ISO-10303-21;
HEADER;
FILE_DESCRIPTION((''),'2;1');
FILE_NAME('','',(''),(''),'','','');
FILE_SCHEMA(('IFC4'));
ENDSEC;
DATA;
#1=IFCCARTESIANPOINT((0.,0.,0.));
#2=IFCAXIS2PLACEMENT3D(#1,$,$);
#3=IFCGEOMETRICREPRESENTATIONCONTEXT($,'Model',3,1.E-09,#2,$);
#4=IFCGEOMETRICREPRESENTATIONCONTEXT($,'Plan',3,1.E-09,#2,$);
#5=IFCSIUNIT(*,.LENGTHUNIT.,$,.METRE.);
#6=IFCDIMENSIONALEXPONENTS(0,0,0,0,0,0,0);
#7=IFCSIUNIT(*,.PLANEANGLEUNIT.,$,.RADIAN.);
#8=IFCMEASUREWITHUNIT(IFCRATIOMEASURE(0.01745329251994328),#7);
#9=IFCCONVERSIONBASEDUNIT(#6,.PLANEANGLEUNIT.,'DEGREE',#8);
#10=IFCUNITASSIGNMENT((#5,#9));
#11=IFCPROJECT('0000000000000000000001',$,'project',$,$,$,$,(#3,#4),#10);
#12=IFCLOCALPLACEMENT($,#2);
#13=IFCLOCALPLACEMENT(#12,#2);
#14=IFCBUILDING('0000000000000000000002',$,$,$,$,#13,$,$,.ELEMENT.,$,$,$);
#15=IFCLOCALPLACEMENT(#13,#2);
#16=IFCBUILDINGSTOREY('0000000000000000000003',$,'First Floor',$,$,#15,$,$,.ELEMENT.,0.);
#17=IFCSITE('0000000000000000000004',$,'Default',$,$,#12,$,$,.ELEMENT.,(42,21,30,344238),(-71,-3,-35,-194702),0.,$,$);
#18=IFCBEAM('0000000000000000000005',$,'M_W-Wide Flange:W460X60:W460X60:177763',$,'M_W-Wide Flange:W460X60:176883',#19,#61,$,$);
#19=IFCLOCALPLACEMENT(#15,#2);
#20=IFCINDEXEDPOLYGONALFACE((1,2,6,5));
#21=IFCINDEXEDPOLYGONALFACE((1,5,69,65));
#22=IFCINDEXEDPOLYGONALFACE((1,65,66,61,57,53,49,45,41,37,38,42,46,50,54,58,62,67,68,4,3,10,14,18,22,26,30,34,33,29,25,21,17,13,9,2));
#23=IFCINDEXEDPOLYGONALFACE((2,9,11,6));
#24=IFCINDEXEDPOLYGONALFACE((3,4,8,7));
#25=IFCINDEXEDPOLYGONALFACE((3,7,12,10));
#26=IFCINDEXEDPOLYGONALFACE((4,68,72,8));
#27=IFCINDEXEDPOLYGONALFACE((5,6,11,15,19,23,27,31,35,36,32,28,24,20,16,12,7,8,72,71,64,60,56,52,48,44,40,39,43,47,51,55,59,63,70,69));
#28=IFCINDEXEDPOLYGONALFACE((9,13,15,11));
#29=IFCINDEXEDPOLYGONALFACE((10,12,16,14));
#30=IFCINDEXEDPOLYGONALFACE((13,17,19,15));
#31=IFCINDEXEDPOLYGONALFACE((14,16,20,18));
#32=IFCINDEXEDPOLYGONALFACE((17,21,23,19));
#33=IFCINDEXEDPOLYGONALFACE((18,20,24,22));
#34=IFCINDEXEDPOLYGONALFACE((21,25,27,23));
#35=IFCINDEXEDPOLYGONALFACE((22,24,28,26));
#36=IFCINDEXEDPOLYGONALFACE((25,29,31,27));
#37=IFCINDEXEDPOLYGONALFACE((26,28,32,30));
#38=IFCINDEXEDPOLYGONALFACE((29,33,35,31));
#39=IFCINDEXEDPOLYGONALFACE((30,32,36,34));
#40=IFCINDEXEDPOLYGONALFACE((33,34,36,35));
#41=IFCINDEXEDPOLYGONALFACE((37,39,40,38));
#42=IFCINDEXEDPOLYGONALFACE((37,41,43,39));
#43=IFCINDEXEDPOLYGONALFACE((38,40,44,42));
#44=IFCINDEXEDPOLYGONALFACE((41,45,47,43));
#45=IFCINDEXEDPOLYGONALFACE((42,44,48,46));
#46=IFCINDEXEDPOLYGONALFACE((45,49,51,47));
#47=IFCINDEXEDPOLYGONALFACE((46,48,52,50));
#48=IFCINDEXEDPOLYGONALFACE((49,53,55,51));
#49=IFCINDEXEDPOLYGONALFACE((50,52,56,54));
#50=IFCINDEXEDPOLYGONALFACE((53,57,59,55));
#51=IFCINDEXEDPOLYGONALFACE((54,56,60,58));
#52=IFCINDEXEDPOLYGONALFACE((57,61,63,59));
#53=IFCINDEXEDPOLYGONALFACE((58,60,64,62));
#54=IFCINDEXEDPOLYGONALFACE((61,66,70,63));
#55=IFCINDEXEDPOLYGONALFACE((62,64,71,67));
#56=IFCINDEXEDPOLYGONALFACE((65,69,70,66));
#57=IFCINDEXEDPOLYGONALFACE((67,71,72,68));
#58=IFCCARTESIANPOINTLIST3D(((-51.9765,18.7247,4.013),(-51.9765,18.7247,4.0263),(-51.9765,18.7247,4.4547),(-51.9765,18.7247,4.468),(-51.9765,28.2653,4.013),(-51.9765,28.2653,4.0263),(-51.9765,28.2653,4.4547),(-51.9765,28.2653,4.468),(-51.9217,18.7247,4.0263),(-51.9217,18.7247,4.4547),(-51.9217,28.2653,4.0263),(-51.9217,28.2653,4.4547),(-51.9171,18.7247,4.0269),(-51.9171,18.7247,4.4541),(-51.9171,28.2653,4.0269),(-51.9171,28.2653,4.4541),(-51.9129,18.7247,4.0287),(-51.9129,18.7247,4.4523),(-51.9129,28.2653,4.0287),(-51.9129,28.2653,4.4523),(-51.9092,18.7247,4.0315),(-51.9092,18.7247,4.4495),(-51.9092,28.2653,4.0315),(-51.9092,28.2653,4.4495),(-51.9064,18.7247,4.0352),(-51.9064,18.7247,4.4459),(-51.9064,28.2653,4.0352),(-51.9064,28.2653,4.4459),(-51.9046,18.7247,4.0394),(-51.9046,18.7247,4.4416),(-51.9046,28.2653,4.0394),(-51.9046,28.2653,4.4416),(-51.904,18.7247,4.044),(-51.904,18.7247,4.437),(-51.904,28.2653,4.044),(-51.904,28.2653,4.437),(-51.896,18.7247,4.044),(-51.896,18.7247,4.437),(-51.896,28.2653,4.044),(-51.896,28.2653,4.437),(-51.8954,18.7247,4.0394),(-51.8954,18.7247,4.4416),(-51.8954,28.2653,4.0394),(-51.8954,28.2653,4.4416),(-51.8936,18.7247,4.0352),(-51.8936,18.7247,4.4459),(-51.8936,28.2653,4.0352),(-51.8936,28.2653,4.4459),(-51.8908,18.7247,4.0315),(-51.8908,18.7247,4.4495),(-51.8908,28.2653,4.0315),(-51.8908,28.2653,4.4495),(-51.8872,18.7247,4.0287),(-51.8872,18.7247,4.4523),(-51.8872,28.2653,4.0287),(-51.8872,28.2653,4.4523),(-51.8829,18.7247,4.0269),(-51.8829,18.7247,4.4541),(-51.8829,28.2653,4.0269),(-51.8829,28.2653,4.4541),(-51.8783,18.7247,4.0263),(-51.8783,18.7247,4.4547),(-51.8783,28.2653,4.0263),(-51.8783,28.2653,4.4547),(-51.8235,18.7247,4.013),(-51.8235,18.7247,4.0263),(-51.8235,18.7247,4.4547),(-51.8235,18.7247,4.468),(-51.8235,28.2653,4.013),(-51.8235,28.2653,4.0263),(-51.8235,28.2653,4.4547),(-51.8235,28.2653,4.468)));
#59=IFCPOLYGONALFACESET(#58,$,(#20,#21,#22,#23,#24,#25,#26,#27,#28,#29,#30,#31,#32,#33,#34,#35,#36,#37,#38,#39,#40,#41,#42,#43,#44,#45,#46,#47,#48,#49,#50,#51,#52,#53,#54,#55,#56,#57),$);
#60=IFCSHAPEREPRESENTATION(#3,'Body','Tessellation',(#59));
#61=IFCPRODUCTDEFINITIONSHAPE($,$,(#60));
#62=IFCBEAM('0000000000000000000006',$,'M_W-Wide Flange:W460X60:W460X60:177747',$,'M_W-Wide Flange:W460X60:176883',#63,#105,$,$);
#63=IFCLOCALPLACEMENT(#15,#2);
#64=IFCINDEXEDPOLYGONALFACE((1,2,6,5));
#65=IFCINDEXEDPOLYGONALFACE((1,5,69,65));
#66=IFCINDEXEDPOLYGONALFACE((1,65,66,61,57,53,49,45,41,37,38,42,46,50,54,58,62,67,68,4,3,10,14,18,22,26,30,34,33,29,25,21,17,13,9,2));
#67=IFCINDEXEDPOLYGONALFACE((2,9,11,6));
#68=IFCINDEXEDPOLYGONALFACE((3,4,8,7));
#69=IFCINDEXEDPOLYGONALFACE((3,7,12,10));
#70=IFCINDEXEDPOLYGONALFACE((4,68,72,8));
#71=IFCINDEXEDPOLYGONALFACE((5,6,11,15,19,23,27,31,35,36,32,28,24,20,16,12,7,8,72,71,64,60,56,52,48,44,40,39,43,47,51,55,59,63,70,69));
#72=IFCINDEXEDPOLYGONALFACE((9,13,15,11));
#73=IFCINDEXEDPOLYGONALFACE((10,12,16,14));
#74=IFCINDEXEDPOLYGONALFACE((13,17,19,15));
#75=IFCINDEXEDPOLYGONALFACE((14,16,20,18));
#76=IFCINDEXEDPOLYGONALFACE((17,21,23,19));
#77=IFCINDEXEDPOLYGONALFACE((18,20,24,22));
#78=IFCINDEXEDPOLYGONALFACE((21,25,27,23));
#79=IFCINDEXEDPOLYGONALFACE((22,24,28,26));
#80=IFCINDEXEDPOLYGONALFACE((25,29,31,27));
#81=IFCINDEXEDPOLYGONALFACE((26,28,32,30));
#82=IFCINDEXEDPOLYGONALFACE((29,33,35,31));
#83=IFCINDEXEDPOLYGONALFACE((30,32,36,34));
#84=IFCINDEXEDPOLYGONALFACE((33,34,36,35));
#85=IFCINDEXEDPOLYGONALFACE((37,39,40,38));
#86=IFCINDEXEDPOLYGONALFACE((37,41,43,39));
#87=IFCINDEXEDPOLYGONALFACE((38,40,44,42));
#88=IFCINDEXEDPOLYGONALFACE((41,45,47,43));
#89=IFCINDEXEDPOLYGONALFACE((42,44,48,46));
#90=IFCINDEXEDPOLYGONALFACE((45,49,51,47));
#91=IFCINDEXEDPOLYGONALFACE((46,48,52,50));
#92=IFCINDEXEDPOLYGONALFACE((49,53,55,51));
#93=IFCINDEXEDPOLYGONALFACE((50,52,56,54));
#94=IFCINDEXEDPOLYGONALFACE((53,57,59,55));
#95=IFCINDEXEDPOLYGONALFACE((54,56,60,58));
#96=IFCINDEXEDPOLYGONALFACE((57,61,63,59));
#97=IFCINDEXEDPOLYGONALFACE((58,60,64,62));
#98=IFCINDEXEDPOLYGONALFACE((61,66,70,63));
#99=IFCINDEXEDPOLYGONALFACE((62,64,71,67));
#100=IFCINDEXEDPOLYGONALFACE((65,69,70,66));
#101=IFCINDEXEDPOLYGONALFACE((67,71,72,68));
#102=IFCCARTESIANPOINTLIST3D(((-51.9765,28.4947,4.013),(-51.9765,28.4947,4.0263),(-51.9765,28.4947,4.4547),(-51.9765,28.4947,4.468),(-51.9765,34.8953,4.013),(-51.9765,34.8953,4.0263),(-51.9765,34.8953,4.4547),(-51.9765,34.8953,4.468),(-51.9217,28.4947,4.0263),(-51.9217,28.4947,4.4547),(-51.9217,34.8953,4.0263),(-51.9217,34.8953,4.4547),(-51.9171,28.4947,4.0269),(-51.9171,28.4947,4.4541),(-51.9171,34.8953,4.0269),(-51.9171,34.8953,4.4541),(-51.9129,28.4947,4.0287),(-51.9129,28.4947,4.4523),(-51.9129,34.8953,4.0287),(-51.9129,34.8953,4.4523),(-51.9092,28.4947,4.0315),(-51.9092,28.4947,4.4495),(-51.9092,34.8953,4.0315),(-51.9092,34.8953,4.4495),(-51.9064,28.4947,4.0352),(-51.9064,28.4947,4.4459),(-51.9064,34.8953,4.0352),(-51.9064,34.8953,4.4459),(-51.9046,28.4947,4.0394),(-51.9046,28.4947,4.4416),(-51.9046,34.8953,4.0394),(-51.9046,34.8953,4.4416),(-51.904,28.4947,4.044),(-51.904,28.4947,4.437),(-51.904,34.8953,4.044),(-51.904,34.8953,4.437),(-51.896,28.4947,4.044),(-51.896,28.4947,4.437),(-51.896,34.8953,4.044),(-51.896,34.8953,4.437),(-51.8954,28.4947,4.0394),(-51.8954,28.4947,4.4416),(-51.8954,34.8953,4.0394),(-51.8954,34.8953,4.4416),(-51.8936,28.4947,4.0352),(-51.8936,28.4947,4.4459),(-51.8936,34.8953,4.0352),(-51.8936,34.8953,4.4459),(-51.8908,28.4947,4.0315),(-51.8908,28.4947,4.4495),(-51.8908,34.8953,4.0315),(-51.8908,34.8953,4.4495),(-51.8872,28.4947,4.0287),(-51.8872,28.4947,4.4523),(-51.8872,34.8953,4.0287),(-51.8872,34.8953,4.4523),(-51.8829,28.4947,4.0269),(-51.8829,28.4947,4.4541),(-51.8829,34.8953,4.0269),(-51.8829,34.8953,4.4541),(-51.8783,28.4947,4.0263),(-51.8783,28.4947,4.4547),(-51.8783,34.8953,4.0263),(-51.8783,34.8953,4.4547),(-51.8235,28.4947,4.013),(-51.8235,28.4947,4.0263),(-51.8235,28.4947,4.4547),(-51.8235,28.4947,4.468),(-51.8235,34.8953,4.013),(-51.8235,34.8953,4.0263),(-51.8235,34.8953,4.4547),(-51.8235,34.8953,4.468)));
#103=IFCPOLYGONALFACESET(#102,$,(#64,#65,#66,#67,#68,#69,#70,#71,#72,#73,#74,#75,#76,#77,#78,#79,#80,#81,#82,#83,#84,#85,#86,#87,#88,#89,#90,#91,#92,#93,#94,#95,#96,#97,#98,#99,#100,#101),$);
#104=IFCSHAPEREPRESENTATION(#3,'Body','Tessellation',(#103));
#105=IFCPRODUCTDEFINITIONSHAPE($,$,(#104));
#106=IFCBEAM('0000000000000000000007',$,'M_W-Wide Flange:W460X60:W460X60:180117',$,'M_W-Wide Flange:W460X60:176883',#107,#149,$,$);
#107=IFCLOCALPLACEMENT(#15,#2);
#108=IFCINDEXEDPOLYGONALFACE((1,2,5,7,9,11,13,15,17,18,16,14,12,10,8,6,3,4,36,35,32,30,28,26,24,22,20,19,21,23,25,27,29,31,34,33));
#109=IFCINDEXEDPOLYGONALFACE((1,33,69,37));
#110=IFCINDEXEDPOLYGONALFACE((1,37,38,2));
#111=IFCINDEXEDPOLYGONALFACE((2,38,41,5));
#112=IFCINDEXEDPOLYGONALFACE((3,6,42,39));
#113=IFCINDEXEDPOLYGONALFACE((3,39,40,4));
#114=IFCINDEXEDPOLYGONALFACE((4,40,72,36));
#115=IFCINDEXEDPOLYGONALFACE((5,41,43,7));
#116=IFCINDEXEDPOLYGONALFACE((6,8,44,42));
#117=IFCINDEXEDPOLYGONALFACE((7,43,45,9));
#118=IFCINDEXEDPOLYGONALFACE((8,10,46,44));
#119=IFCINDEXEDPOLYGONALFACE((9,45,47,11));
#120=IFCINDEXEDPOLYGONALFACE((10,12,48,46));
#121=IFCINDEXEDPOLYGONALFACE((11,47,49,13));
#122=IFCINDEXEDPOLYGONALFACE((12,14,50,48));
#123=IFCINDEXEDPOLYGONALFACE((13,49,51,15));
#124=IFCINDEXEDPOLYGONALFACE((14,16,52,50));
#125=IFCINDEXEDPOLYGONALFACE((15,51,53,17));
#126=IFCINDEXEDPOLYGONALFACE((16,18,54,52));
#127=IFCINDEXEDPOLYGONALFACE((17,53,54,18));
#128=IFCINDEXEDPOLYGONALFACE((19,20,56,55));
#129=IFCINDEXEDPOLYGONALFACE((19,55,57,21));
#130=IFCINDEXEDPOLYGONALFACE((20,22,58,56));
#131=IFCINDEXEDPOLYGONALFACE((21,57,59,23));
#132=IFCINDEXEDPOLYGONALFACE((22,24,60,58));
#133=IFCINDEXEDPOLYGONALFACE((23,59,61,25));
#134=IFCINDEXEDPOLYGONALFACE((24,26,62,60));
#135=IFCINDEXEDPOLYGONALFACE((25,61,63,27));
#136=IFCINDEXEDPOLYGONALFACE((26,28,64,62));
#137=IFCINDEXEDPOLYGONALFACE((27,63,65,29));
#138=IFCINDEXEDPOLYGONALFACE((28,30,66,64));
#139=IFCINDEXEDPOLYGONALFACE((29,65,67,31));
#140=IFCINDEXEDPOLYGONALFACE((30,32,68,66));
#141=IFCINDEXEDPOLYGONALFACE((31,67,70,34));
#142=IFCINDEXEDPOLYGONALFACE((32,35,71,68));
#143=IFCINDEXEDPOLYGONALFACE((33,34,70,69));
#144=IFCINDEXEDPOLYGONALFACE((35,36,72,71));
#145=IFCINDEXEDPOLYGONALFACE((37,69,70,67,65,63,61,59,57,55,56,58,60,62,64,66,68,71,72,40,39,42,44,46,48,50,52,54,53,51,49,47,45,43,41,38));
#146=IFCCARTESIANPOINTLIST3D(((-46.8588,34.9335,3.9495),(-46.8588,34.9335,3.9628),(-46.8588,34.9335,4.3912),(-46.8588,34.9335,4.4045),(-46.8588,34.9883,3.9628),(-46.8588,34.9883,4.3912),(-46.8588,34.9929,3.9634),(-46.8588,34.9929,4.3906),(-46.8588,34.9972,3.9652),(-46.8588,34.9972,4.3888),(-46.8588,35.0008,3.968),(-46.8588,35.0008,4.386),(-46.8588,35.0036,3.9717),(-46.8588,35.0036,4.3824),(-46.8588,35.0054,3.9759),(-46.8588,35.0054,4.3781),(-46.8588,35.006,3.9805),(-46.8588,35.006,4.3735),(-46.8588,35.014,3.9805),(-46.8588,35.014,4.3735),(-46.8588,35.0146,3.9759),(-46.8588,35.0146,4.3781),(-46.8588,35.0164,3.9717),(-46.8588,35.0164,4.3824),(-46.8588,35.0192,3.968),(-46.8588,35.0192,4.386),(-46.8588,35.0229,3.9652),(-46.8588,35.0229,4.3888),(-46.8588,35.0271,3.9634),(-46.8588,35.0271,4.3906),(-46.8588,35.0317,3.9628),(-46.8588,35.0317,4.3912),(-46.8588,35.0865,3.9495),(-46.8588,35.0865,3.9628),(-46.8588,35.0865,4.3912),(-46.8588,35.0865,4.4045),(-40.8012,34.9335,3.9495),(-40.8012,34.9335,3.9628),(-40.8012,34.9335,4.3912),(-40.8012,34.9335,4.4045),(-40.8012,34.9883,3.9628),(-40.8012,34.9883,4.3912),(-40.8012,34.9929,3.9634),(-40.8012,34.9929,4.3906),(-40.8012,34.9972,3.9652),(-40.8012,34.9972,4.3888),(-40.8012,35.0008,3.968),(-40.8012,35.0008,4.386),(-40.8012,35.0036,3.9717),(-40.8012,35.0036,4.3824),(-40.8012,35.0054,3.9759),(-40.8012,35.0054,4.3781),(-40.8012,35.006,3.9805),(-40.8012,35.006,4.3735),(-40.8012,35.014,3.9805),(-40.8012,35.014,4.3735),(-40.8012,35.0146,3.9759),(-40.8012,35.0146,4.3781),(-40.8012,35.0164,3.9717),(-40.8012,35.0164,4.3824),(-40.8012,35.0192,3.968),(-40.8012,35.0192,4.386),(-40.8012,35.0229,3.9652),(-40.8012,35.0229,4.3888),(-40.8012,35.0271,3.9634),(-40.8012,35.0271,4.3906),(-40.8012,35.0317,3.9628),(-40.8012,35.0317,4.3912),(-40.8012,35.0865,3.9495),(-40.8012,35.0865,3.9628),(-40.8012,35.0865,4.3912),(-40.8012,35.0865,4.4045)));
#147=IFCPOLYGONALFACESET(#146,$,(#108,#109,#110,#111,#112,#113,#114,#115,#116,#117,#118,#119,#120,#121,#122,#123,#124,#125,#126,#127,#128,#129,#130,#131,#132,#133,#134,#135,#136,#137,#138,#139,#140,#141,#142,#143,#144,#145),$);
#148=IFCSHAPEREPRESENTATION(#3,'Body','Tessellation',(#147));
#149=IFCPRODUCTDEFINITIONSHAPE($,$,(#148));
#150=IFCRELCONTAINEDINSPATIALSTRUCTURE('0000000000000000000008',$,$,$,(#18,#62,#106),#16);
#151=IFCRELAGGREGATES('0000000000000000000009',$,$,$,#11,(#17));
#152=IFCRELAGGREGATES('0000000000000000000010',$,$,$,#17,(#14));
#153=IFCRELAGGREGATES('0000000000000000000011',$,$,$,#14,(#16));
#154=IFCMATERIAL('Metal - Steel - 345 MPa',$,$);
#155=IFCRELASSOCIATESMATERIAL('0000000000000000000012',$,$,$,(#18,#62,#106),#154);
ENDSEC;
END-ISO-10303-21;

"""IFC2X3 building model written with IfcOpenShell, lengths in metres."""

from ifc_helpers import new_model, entity, si_unit, converted_unit, frame, frame_2d, origin, place, context, project, spatial, polyline, circle_curve, parameter, trimmed, segment, composite_curve, outline, extrude, material, element, save


model = new_model("IFC2X3")

# Units and contexts
model_context = context("Model", 3, precision=1e-09, world=origin())
plan_context = context("Plan", 3, precision=1e-09, world=origin())
ifc_project = project(units=[si_unit("LENGTHUNIT", "METRE"), converted_unit("PLANEANGLEUNIT", "DEGREE", entity("IfcRatioMeasure", 0.01745329251994328), si_unit("PLANEANGLEUNIT", "RADIAN"), dimensions=[0, 0, 0, 0, 0, 0, 0])], contexts=[model_context, plan_context])

# Site, building, storey
site_placement = place(None, origin())
site = spatial("IfcSite", under=ifc_project, at=site_placement, Name="Default", CompositionType="ELEMENT", RefLatitude=(42, 21, 30, 344238), RefLongitude=(-71, -3, -35, -194702), RefElevation=0.0)
building_placement = place(site_placement, origin())
building = spatial("IfcBuilding", under=site, at=building_placement, CompositionType="ELEMENT")
storey_placement = place(building_placement, origin())
storey = spatial("IfcBuildingStorey", under=building, at=storey_placement, Name="First Floor", CompositionType="ELEMENT", Elevation=0.0)

# Beams
ifc_material = material(Name="Metal - Steel - 345 MPa")
beam_1_placement = place(storey_placement, frame((-51.9, 28.3814, 4.468), z_axis=(0.0, 0.0, 1.0), x_axis=(-1.0, 0.0, 0.0)))
element("IfcBeam", 1, at=beam_1_placement, inside=storey, material=ifc_material, Name="M_W-Wide Flange:W460X60:W460X60:177763", ObjectType="M_W-Wide Flange:W460X60:176883", context=model_context, shape_type="SweptSolid", body=[
    extrude(outline(composite_curve([segment(polyline([(0.2142, -0.0765), (0.2275, -0.0765)]), True, "CONTINUOUS"), segment(polyline([(0.2275, -0.0765), (0.2275, 0.0765)]), True, "CONTINUOUS"), segment(polyline([(0.2275, 0.0765), (0.2142, 0.0765)]), True, "CONTINUOUS"), segment(polyline([(0.2142, 0.0765), (0.2142, 0.0217)]), True, "CONTINUOUS"), segment(trimmed(circle_curve(frame_2d((0.1965, 0.0217), x_axis=(1.0, 0.0)), 0.0177), [parameter(270.0)], [parameter(360.0)], True, "PARAMETER"), False, "CONTINUOUS"), segment(polyline([(0.1965, 0.004), (-0.1965, 0.004)]), True, "CONTINUOUS"), segment(trimmed(circle_curve(frame_2d((-0.1965, 0.0217), x_axis=(0.0, -1.0)), 0.0177), [parameter(270.0)], [parameter(360.0)], True, "PARAMETER"), False, "CONTINUOUS"), segment(polyline([(-0.2142, 0.0217), (-0.2142, 0.0765)]), True, "CONTINUOUS"), segment(polyline([(-0.2142, 0.0765), (-0.2275, 0.0765)]), True, "CONTINUOUS"), segment(polyline([(-0.2275, 0.0765), (-0.2275, -0.0765)]), True, "CONTINUOUS"), segment(polyline([(-0.2275, -0.0765), (-0.2142, -0.0765)]), True, "CONTINUOUS"), segment(polyline([(-0.2142, -0.0765), (-0.2142, -0.0217)]), True, "CONTINUOUS"), segment(trimmed(circle_curve(frame_2d((-0.1965, -0.0217), x_axis=(-1.0, 0.0)), 0.0177), [parameter(270.0)], [parameter(360.0)], True, "PARAMETER"), False, "CONTINUOUS"), segment(polyline([(-0.1965, -0.004), (0.1965, -0.004)]), True, "CONTINUOUS"), segment(trimmed(circle_curve(frame_2d((0.1965, -0.0217), x_axis=(0.0, 1.0)), 0.0177), [parameter(270.0)], [parameter(0.0)], True, "PARAMETER"), False, "CONTINUOUS"), segment(polyline([(0.2142, -0.0217), (0.2142, -0.0765)]), True, "CONTINUOUS")], self_intersect=False)), frame((0.0, 9.6567, -0.2275), z_axis=(0.0, -1.0, 0.0), x_axis=(0.0, 0.0, -1.0)), (0.0, 0.0, 1.0), 9.5406),
])
beam_2_placement = place(storey_placement, frame((-51.9, 35.0121, 4.468), z_axis=(0.0, 0.0, 1.0), x_axis=(-1.0, 0.0, 0.0)))
element("IfcBeam", 2, at=beam_2_placement, inside=storey, material=ifc_material, Name="M_W-Wide Flange:W460X60:W460X60:177747", ObjectType="M_W-Wide Flange:W460X60:176883", context=model_context, shape_type="SweptSolid", body=[
    extrude(outline(composite_curve([segment(polyline([(0.2142, -0.0765), (0.2275, -0.0765)]), True, "CONTINUOUS"), segment(polyline([(0.2275, -0.0765), (0.2275, 0.0765)]), True, "CONTINUOUS"), segment(polyline([(0.2275, 0.0765), (0.2142, 0.0765)]), True, "CONTINUOUS"), segment(polyline([(0.2142, 0.0765), (0.2142, 0.0217)]), True, "CONTINUOUS"), segment(trimmed(circle_curve(frame_2d((0.1965, 0.0217), x_axis=(1.0, 0.0)), 0.0177), [parameter(270.0)], [parameter(360.0)], True, "PARAMETER"), False, "CONTINUOUS"), segment(polyline([(0.1965, 0.004), (-0.1965, 0.004)]), True, "CONTINUOUS"), segment(trimmed(circle_curve(frame_2d((-0.1965, 0.0217), x_axis=(0.0, -1.0)), 0.0177), [parameter(270.0)], [parameter(360.0)], True, "PARAMETER"), False, "CONTINUOUS"), segment(polyline([(-0.2142, 0.0217), (-0.2142, 0.0765)]), True, "CONTINUOUS"), segment(polyline([(-0.2142, 0.0765), (-0.2275, 0.0765)]), True, "CONTINUOUS"), segment(polyline([(-0.2275, 0.0765), (-0.2275, -0.0765)]), True, "CONTINUOUS"), segment(polyline([(-0.2275, -0.0765), (-0.2142, -0.0765)]), True, "CONTINUOUS"), segment(polyline([(-0.2142, -0.0765), (-0.2142, -0.0217)]), True, "CONTINUOUS"), segment(trimmed(circle_curve(frame_2d((-0.1965, -0.0217), x_axis=(-1.0, 0.0)), 0.0177), [parameter(270.0)], [parameter(360.0)], True, "PARAMETER"), False, "CONTINUOUS"), segment(polyline([(-0.1965, -0.004), (0.1965, -0.004)]), True, "CONTINUOUS"), segment(trimmed(circle_curve(frame_2d((0.1965, -0.0217), x_axis=(0.0, 1.0)), 0.0177), [parameter(270.0)], [parameter(0.0)], True, "PARAMETER"), False, "CONTINUOUS"), segment(polyline([(0.2142, -0.0217), (0.2142, -0.0765)]), True, "CONTINUOUS")], self_intersect=False)), frame((0.0, 6.5174, -0.2275), z_axis=(0.0, -1.0, 0.0), x_axis=(0.0, 0.0, -1.0)), (0.0, 0.0, 1.0), 6.4006),
])
beam_3_placement = place(storey_placement, frame((-40.6578, 35.01, 4.4045), z_axis=(0.0, 0.0, 1.0), x_axis=(0.0, 1.0, 0.0)))
element("IfcBeam", 3, at=beam_3_placement, inside=storey, material=ifc_material, Name="M_W-Wide Flange:W460X60:W460X60:180117", ObjectType="M_W-Wide Flange:W460X60:176883", context=model_context, shape_type="SweptSolid", body=[
    extrude(outline(composite_curve([segment(polyline([(0.2142, -0.0765), (0.2275, -0.0765)]), True, "CONTINUOUS"), segment(polyline([(0.2275, -0.0765), (0.2275, 0.0765)]), True, "CONTINUOUS"), segment(polyline([(0.2275, 0.0765), (0.2142, 0.0765)]), True, "CONTINUOUS"), segment(polyline([(0.2142, 0.0765), (0.2142, 0.0217)]), True, "CONTINUOUS"), segment(trimmed(circle_curve(frame_2d((0.1965, 0.0217), x_axis=(0.0, 1.0)), 0.0177), [parameter(180.0)], [parameter(270.0)], True, "PARAMETER"), False, "CONTINUOUS"), segment(polyline([(0.1965, 0.004), (-0.1965, 0.004)]), True, "CONTINUOUS"), segment(trimmed(circle_curve(frame_2d((-0.1965, 0.0217), x_axis=(0.0, 1.0)), 0.0177), [parameter(90.0)], [parameter(180.0)], True, "PARAMETER"), False, "CONTINUOUS"), segment(polyline([(-0.2142, 0.0217), (-0.2142, 0.0765)]), True, "CONTINUOUS"), segment(polyline([(-0.2142, 0.0765), (-0.2275, 0.0765)]), True, "CONTINUOUS"), segment(polyline([(-0.2275, 0.0765), (-0.2275, -0.0765)]), True, "CONTINUOUS"), segment(polyline([(-0.2275, -0.0765), (-0.2142, -0.0765)]), True, "CONTINUOUS"), segment(polyline([(-0.2142, -0.0765), (-0.2142, -0.0217)]), True, "CONTINUOUS"), segment(trimmed(circle_curve(frame_2d((-0.1965, -0.0217), x_axis=(0.0, 1.0)), 0.0177), [parameter(360.0)], [parameter(90.0)], True, "PARAMETER"), False, "CONTINUOUS"), segment(polyline([(-0.1965, -0.004), (0.1965, -0.004)]), True, "CONTINUOUS"), segment(trimmed(circle_curve(frame_2d((0.1965, -0.0217), x_axis=(0.0, 1.0)), 0.0177), [parameter(270.0)], [parameter(0.0)], True, "PARAMETER"), False, "CONTINUOUS"), segment(polyline([(0.2142, -0.0217), (0.2142, -0.0765)]), True, "CONTINUOUS")], self_intersect=False)), frame((0.0, 6.201, -0.2275), z_axis=(0.0, -1.0, 0.0), x_axis=(0.0, 0.0, -1.0)), (0.0, 0.0, 1.0), 6.0576),
])

save(model, "model.ifc")
